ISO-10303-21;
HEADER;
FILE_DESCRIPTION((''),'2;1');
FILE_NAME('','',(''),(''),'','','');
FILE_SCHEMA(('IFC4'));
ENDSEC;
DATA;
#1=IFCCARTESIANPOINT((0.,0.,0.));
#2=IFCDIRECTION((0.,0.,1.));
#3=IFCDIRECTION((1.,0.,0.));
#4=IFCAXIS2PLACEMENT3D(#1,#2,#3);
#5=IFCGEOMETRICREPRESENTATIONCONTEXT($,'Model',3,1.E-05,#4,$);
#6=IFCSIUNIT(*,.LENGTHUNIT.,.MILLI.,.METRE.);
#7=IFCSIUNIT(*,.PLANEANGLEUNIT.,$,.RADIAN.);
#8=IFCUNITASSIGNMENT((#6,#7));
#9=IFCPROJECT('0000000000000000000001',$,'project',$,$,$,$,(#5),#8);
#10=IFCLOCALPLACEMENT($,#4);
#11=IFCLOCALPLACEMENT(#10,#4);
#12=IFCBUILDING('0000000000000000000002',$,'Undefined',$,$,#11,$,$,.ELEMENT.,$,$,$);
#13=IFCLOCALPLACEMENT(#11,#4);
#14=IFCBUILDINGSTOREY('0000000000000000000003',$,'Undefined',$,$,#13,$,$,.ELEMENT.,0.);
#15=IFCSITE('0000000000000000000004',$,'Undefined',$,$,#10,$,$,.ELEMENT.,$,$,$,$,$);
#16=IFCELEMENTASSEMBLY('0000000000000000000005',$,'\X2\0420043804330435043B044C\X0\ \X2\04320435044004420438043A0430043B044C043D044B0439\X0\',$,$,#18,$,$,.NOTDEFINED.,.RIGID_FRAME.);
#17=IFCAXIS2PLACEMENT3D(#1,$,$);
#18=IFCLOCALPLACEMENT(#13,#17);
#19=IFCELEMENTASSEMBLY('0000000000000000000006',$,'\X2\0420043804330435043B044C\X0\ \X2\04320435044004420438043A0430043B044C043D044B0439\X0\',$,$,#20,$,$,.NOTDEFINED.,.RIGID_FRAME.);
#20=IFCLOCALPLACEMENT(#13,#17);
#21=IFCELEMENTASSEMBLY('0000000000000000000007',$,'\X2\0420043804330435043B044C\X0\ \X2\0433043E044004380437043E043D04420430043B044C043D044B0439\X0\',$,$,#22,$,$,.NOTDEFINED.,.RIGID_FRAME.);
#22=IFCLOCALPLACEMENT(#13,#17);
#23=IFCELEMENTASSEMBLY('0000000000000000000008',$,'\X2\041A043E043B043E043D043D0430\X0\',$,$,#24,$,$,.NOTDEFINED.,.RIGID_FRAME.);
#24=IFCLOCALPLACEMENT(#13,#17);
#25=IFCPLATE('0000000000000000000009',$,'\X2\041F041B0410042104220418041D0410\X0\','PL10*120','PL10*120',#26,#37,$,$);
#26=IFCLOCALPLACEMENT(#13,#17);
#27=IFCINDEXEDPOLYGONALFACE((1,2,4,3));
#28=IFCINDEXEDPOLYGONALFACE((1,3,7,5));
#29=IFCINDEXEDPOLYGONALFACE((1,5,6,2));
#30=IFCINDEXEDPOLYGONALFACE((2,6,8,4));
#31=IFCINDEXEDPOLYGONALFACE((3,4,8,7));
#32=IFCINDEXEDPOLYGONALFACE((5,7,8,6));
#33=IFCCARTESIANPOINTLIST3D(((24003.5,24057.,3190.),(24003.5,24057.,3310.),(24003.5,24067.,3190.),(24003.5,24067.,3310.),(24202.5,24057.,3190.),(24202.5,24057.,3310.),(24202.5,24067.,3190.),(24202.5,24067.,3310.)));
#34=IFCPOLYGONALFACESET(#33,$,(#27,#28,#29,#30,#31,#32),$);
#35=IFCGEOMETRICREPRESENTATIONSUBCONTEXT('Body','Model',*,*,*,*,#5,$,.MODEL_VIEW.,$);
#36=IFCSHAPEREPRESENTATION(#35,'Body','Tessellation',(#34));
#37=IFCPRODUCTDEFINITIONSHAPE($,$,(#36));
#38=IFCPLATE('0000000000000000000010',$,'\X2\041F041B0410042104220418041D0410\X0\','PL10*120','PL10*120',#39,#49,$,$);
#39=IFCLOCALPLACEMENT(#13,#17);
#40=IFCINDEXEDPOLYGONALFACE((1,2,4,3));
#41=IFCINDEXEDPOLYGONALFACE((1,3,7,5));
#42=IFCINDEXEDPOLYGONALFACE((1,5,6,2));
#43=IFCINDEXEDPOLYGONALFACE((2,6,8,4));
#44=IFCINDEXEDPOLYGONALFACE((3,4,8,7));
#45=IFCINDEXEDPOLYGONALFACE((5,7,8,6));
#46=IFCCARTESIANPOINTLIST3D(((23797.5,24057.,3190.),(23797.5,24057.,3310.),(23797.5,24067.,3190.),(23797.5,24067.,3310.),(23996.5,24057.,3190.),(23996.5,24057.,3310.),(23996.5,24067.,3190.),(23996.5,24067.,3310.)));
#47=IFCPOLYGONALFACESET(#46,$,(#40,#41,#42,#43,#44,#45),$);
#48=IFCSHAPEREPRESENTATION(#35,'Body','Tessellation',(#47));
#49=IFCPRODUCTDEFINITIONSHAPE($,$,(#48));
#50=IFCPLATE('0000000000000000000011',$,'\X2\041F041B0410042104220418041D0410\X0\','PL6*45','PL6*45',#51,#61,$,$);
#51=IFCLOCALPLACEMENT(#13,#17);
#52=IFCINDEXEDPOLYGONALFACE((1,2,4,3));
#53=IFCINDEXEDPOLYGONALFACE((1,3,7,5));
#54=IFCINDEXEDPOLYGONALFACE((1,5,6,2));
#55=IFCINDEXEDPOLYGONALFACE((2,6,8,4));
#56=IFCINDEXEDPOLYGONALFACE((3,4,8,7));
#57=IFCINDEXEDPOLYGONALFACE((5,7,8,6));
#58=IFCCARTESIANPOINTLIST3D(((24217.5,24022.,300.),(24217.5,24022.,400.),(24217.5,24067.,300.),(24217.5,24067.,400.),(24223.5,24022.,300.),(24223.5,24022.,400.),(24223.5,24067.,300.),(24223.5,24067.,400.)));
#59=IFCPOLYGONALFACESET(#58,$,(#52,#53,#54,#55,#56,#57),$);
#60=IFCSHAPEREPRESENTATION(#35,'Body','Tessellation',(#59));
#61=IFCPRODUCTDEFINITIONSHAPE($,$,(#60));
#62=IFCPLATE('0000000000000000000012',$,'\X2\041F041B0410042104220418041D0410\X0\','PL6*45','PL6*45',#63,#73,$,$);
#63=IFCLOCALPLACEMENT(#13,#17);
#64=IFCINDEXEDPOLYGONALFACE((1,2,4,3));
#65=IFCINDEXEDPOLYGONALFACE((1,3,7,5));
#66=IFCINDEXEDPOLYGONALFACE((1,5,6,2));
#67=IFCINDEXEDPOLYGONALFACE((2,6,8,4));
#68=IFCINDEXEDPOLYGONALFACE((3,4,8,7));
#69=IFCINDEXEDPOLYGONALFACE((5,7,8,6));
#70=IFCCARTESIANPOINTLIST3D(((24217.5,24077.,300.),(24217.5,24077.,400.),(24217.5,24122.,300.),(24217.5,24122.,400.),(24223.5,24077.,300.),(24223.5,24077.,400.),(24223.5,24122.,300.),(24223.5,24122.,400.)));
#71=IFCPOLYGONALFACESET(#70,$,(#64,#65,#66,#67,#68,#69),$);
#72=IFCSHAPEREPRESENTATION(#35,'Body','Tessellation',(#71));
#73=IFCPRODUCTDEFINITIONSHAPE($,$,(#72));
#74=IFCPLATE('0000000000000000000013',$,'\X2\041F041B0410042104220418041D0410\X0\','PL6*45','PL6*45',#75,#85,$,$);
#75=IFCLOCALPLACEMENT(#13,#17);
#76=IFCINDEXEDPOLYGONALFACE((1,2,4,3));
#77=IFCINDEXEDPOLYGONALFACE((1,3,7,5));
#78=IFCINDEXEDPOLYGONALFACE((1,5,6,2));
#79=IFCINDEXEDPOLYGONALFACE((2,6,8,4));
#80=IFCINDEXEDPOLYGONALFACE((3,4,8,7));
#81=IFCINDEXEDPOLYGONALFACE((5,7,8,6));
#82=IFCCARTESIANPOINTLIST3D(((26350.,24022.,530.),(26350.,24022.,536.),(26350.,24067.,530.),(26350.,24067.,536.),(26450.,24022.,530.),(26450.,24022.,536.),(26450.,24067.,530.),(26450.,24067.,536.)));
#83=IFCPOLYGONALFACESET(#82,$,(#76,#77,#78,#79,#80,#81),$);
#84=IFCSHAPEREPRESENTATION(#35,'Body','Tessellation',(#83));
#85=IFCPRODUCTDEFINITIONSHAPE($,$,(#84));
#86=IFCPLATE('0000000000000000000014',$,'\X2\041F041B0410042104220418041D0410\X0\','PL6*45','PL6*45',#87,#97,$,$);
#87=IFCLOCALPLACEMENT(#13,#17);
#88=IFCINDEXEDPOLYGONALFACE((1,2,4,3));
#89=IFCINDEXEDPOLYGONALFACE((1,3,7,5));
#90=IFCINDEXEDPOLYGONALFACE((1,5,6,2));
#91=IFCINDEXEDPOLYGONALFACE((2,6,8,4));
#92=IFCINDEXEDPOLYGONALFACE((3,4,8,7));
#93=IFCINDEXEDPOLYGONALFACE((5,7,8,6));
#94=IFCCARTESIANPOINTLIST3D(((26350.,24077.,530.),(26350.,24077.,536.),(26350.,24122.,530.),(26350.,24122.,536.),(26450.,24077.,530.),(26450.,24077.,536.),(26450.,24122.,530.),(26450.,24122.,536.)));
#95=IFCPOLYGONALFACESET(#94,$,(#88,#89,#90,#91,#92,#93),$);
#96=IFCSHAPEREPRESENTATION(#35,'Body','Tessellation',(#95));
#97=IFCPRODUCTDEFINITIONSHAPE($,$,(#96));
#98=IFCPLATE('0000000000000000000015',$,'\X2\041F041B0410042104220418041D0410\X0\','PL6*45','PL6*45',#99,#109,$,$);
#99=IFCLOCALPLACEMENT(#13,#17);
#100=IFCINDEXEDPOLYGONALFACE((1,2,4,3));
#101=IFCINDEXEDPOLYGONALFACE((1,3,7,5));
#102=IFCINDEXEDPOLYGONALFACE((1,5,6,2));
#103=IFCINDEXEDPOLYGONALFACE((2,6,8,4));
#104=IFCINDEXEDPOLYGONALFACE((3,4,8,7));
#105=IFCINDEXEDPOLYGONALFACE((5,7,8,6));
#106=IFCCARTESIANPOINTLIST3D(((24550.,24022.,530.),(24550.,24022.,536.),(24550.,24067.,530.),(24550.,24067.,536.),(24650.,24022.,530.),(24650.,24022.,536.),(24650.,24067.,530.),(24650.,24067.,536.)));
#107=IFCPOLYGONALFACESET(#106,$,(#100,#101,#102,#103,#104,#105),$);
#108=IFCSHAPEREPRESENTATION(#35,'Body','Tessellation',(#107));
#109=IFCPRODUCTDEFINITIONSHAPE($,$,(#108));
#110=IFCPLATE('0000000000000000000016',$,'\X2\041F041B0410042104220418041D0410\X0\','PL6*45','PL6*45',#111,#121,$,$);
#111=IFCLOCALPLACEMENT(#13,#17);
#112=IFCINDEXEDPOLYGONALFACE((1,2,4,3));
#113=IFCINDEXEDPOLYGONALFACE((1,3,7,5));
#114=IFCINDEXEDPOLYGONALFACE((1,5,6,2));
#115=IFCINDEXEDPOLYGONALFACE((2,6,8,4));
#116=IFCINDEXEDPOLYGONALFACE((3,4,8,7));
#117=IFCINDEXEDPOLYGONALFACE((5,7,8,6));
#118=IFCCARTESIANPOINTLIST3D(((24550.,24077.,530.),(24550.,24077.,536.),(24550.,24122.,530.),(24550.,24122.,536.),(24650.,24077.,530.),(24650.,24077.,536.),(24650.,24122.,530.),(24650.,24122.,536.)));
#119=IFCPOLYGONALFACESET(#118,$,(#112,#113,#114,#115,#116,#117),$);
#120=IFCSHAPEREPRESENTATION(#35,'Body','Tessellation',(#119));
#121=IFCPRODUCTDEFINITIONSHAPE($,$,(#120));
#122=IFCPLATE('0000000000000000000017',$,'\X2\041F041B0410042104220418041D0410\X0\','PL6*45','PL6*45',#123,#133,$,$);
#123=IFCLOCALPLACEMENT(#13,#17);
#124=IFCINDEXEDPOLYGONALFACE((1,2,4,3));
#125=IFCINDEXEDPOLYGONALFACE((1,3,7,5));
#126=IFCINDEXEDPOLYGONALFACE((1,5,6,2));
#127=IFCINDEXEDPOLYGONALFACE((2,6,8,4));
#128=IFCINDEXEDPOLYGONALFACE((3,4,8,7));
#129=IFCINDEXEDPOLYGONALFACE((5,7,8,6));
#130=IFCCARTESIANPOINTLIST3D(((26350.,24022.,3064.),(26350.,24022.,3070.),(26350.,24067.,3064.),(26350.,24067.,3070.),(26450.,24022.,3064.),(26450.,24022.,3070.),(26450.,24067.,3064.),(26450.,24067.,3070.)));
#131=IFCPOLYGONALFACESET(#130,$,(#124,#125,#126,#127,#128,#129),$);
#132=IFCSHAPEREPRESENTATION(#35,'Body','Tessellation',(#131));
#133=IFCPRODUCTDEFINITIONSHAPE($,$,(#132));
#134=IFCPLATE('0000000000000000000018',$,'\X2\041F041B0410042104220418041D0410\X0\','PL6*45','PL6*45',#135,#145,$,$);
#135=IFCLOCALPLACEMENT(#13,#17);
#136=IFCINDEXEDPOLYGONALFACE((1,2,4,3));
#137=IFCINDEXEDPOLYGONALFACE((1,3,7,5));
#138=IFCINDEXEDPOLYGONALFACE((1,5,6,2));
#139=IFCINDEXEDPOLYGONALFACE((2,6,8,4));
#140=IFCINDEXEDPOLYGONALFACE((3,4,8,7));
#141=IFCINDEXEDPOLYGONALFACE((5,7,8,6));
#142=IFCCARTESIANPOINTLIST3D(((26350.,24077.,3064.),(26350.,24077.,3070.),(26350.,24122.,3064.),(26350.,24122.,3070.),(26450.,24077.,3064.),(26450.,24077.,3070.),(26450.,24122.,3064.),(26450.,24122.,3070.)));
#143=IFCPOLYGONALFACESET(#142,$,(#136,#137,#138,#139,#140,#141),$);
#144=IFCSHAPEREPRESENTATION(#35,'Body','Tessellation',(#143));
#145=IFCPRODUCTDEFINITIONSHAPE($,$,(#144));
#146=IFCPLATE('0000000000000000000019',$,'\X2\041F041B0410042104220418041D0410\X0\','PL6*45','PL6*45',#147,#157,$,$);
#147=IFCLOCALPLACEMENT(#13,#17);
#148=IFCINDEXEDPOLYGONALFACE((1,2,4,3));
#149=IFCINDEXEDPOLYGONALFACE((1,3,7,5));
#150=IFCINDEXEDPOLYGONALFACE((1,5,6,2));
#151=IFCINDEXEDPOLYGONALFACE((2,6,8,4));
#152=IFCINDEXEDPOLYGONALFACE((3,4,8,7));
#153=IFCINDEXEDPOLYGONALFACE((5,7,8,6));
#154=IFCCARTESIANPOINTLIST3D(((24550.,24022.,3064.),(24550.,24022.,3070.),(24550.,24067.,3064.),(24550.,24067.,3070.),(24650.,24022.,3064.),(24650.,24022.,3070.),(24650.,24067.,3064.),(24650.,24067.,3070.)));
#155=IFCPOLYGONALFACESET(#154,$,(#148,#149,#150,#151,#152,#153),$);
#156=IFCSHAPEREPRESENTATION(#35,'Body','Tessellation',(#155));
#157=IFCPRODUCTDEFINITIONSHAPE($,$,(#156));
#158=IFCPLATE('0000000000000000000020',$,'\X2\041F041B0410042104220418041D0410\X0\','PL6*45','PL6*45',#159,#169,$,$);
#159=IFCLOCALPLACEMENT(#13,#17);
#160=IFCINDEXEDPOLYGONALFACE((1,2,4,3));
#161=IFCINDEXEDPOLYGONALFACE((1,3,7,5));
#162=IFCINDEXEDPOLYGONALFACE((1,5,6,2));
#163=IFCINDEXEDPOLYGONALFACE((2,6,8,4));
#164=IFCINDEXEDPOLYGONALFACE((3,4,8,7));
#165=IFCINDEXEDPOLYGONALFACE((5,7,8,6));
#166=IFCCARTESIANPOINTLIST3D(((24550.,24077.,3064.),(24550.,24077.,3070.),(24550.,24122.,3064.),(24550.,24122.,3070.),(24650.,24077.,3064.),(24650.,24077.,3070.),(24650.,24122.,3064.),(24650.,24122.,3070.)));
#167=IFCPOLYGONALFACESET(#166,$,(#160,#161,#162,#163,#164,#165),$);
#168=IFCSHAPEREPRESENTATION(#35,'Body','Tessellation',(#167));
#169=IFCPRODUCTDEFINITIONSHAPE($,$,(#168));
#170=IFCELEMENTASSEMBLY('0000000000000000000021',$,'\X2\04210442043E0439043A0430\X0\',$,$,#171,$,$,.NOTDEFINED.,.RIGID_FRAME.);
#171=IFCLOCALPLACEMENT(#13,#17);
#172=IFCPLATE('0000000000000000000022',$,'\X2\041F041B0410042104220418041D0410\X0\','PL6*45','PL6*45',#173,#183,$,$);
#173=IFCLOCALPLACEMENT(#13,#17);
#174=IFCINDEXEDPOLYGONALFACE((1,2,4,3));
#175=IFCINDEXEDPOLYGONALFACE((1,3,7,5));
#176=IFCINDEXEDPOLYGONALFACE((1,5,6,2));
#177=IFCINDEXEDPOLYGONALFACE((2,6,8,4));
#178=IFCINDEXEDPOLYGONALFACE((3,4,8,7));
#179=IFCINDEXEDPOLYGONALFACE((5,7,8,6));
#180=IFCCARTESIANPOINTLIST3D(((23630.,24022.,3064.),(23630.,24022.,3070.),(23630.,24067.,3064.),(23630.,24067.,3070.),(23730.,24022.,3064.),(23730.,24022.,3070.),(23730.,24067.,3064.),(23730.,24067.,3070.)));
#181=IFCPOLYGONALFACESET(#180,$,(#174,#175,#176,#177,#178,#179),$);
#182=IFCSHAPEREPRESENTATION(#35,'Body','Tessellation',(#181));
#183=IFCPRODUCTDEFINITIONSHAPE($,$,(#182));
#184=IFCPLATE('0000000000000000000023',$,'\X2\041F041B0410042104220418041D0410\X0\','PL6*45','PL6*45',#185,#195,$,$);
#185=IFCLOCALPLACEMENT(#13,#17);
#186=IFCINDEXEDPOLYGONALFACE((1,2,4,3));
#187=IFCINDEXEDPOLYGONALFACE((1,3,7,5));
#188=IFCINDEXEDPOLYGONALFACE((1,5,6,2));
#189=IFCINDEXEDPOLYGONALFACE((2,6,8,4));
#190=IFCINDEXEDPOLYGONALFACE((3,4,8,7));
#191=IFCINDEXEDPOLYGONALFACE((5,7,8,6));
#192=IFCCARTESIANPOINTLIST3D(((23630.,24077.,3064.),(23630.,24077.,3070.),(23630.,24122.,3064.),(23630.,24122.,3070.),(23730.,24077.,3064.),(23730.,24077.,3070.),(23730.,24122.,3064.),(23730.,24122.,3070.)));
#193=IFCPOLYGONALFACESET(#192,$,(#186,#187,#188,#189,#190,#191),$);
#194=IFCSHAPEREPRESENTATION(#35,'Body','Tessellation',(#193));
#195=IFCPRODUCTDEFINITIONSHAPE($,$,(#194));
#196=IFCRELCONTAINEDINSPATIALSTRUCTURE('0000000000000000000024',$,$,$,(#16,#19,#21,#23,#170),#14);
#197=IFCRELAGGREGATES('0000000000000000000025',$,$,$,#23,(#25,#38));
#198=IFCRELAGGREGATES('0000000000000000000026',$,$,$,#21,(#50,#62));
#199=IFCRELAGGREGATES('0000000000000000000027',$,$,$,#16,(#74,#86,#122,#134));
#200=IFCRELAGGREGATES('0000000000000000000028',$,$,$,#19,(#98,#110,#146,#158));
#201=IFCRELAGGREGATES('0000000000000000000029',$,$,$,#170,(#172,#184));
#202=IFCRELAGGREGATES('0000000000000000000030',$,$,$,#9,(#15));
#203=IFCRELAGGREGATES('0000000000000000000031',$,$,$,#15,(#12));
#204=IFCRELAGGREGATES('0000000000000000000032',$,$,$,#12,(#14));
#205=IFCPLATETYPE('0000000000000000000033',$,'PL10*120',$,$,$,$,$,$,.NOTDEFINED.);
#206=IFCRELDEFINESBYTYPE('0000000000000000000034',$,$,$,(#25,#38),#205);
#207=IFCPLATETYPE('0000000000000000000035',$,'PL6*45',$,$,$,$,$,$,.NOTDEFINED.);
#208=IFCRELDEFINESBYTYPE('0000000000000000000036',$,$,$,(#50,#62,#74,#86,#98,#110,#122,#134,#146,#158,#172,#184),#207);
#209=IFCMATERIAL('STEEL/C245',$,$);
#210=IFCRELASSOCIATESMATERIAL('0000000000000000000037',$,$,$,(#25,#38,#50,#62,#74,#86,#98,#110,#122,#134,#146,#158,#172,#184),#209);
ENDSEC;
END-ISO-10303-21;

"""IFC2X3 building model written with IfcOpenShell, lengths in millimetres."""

from ifc_helpers import new_model, si_unit, frame, origin_with_axes, place, context, subcontext, project, spatial, polyline, outline, extrude, material, type_object, element, aggregate, save


model = new_model("IFC2X3")

# Units and contexts
model_context = context("Model", 3, precision=1e-05, world=origin_with_axes())
body_context = subcontext(model_context, "Body", "Model", "MODEL_VIEW")
ifc_project = project(units=[si_unit("LENGTHUNIT", "METRE", prefix="MILLI"), si_unit("PLANEANGLEUNIT", "RADIAN")], contexts=[model_context])

# Site, building, storey
site_placement = place(None, origin_with_axes())
site = spatial("IfcSite", under=ifc_project, at=site_placement, Name="Undefined", CompositionType="ELEMENT")
building_placement = place(site_placement, origin_with_axes())
building = spatial("IfcBuilding", under=site, at=building_placement, Name="Undefined", CompositionType="ELEMENT")
storey_placement = place(building_placement, origin_with_axes())
storey = spatial("IfcBuildingStorey", under=building, at=storey_placement, Name="Undefined", CompositionType="ELEMENT", Elevation=0.0)

# Element assemblies
assembly_1_placement = place(storey_placement, origin_with_axes())
assembly_1 = element("IfcElementAssembly", 1, at=assembly_1_placement, inside=storey, Name="Ригель вертикальный", AssemblyPlace="NOTDEFINED", PredefinedType="RIGID_FRAME")
ifc_material_1 = material(Name="STEEL/C245")
assembly_2_placement = place(storey_placement, origin_with_axes())
assembly_2 = element("IfcElementAssembly", 2, at=assembly_2_placement, inside=storey, Name="Ригель вертикальный", AssemblyPlace="NOTDEFINED", PredefinedType="RIGID_FRAME")

# Element assembly
assembly_3_placement = place(storey_placement, origin_with_axes())
assembly_3 = element("IfcElementAssembly", 3, at=assembly_3_placement, inside=storey, Name="Ригель горизонтальный", AssemblyPlace="NOTDEFINED", PredefinedType="RIGID_FRAME")

# Element assembly, plates
assembly_4_placement = place(storey_placement, origin_with_axes())
assembly_4 = element("IfcElementAssembly", 4, at=assembly_4_placement, inside=storey, Name="Колонна", AssemblyPlace="NOTDEFINED", PredefinedType="RIGID_FRAME")
plate_type_1 = type_object("IfcPlateType", Name="PL10*120", PredefinedType="NOTDEFINED")
plate_1_placement = place(assembly_4_placement, frame((24003.5, 24062.0, 3190.0), z_axis=(0.0, -1.0, 0.0), x_axis=(1.0, 0.0, 0.0)))
plate_1 = element("IfcPlate", 5, at=plate_1_placement, type_object=plate_type_1, material=ifc_material_1, Name="ПЛАСТИНА", Description="PL10*120", ObjectType="PL10*120", context=body_context, shape_type="SweptSolid", body=[
    extrude(outline(polyline([(0.0, 0.0), (199.0, 0.0), (199.0, 120.0), (0.0, 120.0), (0.0, 0.0)])), frame((0.0, 0.0, -5.0), z_axis=(0.0, 0.0, 1.0), x_axis=(1.0, 0.0, 0.0)), (0.0, 0.0, 1.0), 10.0),
])
plate_2_placement = place(assembly_4_placement, frame((23996.5, 24062.0, 3190.0), z_axis=(0.0, 1.0, 0.0), x_axis=(-1.0, 0.0, 0.0)))
plate_2 = element("IfcPlate", 6, at=plate_2_placement, type_object=plate_type_1, material=ifc_material_1, Name="ПЛАСТИНА", Description="PL10*120", ObjectType="PL10*120", context=body_context, shape_type="SweptSolid", body=[
    extrude(outline(polyline([(0.0, 0.0), (199.0, 0.0), (199.0, 120.0), (0.0, 120.0), (0.0, 0.0)])), frame((0.0, 0.0, -5.0), z_axis=(0.0, 0.0, 1.0), x_axis=(1.0, 0.0, 0.0)), (0.0, 0.0, 1.0), 10.0),
])
aggregate(assembly_4, [plate_1, plate_2])

# Plates
plate_type_2 = type_object("IfcPlateType", Name="PL6*45", PredefinedType="NOTDEFINED")
plate_3_placement = place(assembly_3_placement, frame((24220.5, 24044.5, 400.0), z_axis=(1.0, 0.0, 0.0), x_axis=(0.0, 0.0, -1.0)))
plate_3 = element("IfcPlate", 7, at=plate_3_placement, type_object=plate_type_2, material=ifc_material_1, Name="ПЛАСТИНА", Description="PL6*45", ObjectType="PL6*45", context=body_context, shape_type="SweptSolid", body=[
    extrude(outline(polyline([(100.0, -22.5), (0.0, -22.5), (0.0, 22.5), (100.0, 22.5), (100.0, -22.5)])), frame((0.0, 0.0, -3.0), z_axis=(0.0, 0.0, 1.0), x_axis=(1.0, 0.0, 0.0)), (0.0, 0.0, 1.0), 6.0),
])
plate_4_placement = place(assembly_3_placement, frame((24220.5, 24099.5, 400.0), z_axis=(-1.0, 0.0, 0.0), x_axis=(0.0, 0.0, -1.0)))
plate_4 = element("IfcPlate", 8, at=plate_4_placement, type_object=plate_type_2, material=ifc_material_1, Name="ПЛАСТИНА", Description="PL6*45", ObjectType="PL6*45", context=body_context, shape_type="SweptSolid", body=[
    extrude(outline(polyline([(100.0, 22.5), (100.0, -22.5), (0.0, -22.5), (0.0, 22.5), (100.0, 22.5)])), frame((0.0, 0.0, -3.0), z_axis=(0.0, 0.0, 1.0), x_axis=(1.0, 0.0, 0.0)), (0.0, 0.0, 1.0), 6.0),
])
plate_5_placement = place(assembly_1_placement, frame((26350.0, 24044.5, 533.0), z_axis=(0.0, 0.0, 1.0), x_axis=(1.0, 0.0, 0.0)))
plate_5 = element("IfcPlate", 9, at=plate_5_placement, type_object=plate_type_2, material=ifc_material_1, Name="ПЛАСТИНА", Description="PL6*45", ObjectType="PL6*45", context=body_context, shape_type="SweptSolid", body=[
    extrude(outline(polyline([(0.0, -22.5), (0.0, 22.5), (100.0, 22.5), (100.0, -22.5), (0.0, -22.5)])), frame((0.0, 0.0, -3.0), z_axis=(0.0, 0.0, 1.0), x_axis=(1.0, 0.0, 0.0)), (0.0, 0.0, 1.0), 6.0),
])
plate_6_placement = place(assembly_1_placement, frame((26350.0, 24099.5, 533.0), z_axis=(0.0, 0.0, -1.0), x_axis=(1.0, 0.0, 0.0)))
plate_6 = element("IfcPlate", 10, at=plate_6_placement, type_object=plate_type_2, material=ifc_material_1, Name="ПЛАСТИНА", Description="PL6*45", ObjectType="PL6*45", context=body_context, shape_type="SweptSolid", body=[
    extrude(outline(polyline([(0.0, 22.5), (100.0, 22.5), (100.0, -22.5), (0.0, -22.5), (0.0, 22.5)])), frame((0.0, 0.0, -3.0), z_axis=(0.0, 0.0, 1.0), x_axis=(1.0, 0.0, 0.0)), (0.0, 0.0, 1.0), 6.0),
])
plate_7_placement = place(assembly_2_placement, frame((24550.0, 24044.5, 533.0), z_axis=(0.0, 0.0, 1.0), x_axis=(1.0, 0.0, 0.0)))
plate_7 = element("IfcPlate", 11, at=plate_7_placement, type_object=plate_type_2, material=ifc_material_1, Name="ПЛАСТИНА", Description="PL6*45", ObjectType="PL6*45", context=body_context, shape_type="SweptSolid", body=[
    extrude(outline(polyline([(0.0, -22.5), (0.0, 22.5), (100.0, 22.5), (100.0, -22.5), (0.0, -22.5)])), frame((0.0, 0.0, -3.0), z_axis=(0.0, 0.0, 1.0), x_axis=(1.0, 0.0, 0.0)), (0.0, 0.0, 1.0), 6.0),
])
plate_8_placement = place(assembly_2_placement, frame((24550.0, 24099.5, 533.0), z_axis=(0.0, 0.0, -1.0), x_axis=(1.0, 0.0, 0.0)))
plate_8 = element("IfcPlate", 12, at=plate_8_placement, type_object=plate_type_2, material=ifc_material_1, Name="ПЛАСТИНА", Description="PL6*45", ObjectType="PL6*45", context=body_context, shape_type="SweptSolid", body=[
    extrude(outline(polyline([(0.0, 22.5), (100.0, 22.5), (100.0, -22.5), (0.0, -22.5), (0.0, 22.5)])), frame((0.0, 0.0, -3.0), z_axis=(0.0, 0.0, 1.0), x_axis=(1.0, 0.0, 0.0)), (0.0, 0.0, 1.0), 6.0),
])
plate_9_placement = place(assembly_1_placement, frame((26450.0, 24044.5, 3067.0), z_axis=(0.0, 0.0, -1.0), x_axis=(-1.0, 0.0, 0.0)))
plate_9 = element("IfcPlate", 13, at=plate_9_placement, type_object=plate_type_2, material=ifc_material_1, Name="ПЛАСТИНА", Description="PL6*45", ObjectType="PL6*45", context=body_context, shape_type="SweptSolid", body=[
    extrude(outline(polyline([(100.0, -22.5), (0.0, -22.5), (0.0, 22.5), (100.0, 22.5), (100.0, -22.5)])), frame((0.0, 0.0, -3.0), z_axis=(0.0, 0.0, 1.0), x_axis=(1.0, 0.0, 0.0)), (0.0, 0.0, 1.0), 6.0),
])
plate_10_placement = place(assembly_1_placement, frame((26450.0, 24099.5, 3067.0), z_axis=(0.0, 0.0, 1.0), x_axis=(-1.0, 0.0, 0.0)))
plate_10 = element("IfcPlate", 14, at=plate_10_placement, type_object=plate_type_2, material=ifc_material_1, Name="ПЛАСТИНА", Description="PL6*45", ObjectType="PL6*45", context=body_context, shape_type="SweptSolid", body=[
    extrude(outline(polyline([(100.0, 22.5), (100.0, -22.5), (0.0, -22.5), (0.0, 22.5), (100.0, 22.5)])), frame((0.0, 0.0, -3.0), z_axis=(0.0, 0.0, 1.0), x_axis=(1.0, 0.0, 0.0)), (0.0, 0.0, 1.0), 6.0),
])
plate_11_placement = place(assembly_2_placement, frame((24650.0, 24044.5, 3067.0), z_axis=(0.0, 0.0, -1.0), x_axis=(-1.0, 0.0, 0.0)))
plate_11 = element("IfcPlate", 15, at=plate_11_placement, type_object=plate_type_2, material=ifc_material_1, Name="ПЛАСТИНА", Description="PL6*45", ObjectType="PL6*45", context=body_context, shape_type="SweptSolid", body=[
    extrude(outline(polyline([(100.0, -22.5), (0.0, -22.5), (0.0, 22.5), (100.0, 22.5), (100.0, -22.5)])), frame((0.0, 0.0, -3.0), z_axis=(0.0, 0.0, 1.0), x_axis=(1.0, 0.0, 0.0)), (0.0, 0.0, 1.0), 6.0),
])
plate_12_placement = place(assembly_2_placement, frame((24650.0, 24099.5, 3067.0), z_axis=(0.0, 0.0, 1.0), x_axis=(-1.0, 0.0, 0.0)))
plate_12 = element("IfcPlate", 16, at=plate_12_placement, type_object=plate_type_2, material=ifc_material_1, Name="ПЛАСТИНА", Description="PL6*45", ObjectType="PL6*45", context=body_context, shape_type="SweptSolid", body=[
    extrude(outline(polyline([(100.0, 22.5), (100.0, -22.5), (0.0, -22.5), (0.0, 22.5), (100.0, 22.5)])), frame((0.0, 0.0, -3.0), z_axis=(0.0, 0.0, 1.0), x_axis=(1.0, 0.0, 0.0)), (0.0, 0.0, 1.0), 6.0),
])

# Element assembly, plates
assembly_5_placement = place(storey_placement, origin_with_axes())
assembly_5 = element("IfcElementAssembly", 17, at=assembly_5_placement, inside=storey, Name="Стойка", AssemblyPlace="NOTDEFINED", PredefinedType="RIGID_FRAME")
plate_13_placement = place(assembly_5_placement, frame((23730.0, 24044.5, 3067.0), z_axis=(0.0, 0.0, -1.0), x_axis=(-1.0, 0.0, 0.0)))
plate_13 = element("IfcPlate", 18, at=plate_13_placement, type_object=plate_type_2, material=ifc_material_1, Name="ПЛАСТИНА", Description="PL6*45", ObjectType="PL6*45", context=body_context, shape_type="SweptSolid", body=[
    extrude(outline(polyline([(100.0, -22.5), (0.0, -22.5), (0.0, 22.5), (100.0, 22.5), (100.0, -22.5)])), frame((0.0, 0.0, -3.0), z_axis=(0.0, 0.0, 1.0), x_axis=(1.0, 0.0, 0.0)), (0.0, 0.0, 1.0), 6.0),
])
plate_14_placement = place(assembly_5_placement, frame((23730.0, 24099.5, 3067.0), z_axis=(0.0, 0.0, 1.0), x_axis=(-1.0, 0.0, 0.0)))
plate_14 = element("IfcPlate", 19, at=plate_14_placement, type_object=plate_type_2, material=ifc_material_1, Name="ПЛАСТИНА", Description="PL6*45", ObjectType="PL6*45", context=body_context, shape_type="SweptSolid", body=[
    extrude(outline(polyline([(100.0, 22.5), (100.0, -22.5), (0.0, -22.5), (0.0, 22.5), (100.0, 22.5)])), frame((0.0, 0.0, -3.0), z_axis=(0.0, 0.0, 1.0), x_axis=(1.0, 0.0, 0.0)), (0.0, 0.0, 1.0), 6.0),
])

aggregate(assembly_3, [plate_3, plate_4])
aggregate(assembly_1, [plate_5, plate_6, plate_9, plate_10])
aggregate(assembly_2, [plate_7, plate_8, plate_11, plate_12])
aggregate(assembly_5, [plate_13, plate_14])

save(model, "model.ifc")
